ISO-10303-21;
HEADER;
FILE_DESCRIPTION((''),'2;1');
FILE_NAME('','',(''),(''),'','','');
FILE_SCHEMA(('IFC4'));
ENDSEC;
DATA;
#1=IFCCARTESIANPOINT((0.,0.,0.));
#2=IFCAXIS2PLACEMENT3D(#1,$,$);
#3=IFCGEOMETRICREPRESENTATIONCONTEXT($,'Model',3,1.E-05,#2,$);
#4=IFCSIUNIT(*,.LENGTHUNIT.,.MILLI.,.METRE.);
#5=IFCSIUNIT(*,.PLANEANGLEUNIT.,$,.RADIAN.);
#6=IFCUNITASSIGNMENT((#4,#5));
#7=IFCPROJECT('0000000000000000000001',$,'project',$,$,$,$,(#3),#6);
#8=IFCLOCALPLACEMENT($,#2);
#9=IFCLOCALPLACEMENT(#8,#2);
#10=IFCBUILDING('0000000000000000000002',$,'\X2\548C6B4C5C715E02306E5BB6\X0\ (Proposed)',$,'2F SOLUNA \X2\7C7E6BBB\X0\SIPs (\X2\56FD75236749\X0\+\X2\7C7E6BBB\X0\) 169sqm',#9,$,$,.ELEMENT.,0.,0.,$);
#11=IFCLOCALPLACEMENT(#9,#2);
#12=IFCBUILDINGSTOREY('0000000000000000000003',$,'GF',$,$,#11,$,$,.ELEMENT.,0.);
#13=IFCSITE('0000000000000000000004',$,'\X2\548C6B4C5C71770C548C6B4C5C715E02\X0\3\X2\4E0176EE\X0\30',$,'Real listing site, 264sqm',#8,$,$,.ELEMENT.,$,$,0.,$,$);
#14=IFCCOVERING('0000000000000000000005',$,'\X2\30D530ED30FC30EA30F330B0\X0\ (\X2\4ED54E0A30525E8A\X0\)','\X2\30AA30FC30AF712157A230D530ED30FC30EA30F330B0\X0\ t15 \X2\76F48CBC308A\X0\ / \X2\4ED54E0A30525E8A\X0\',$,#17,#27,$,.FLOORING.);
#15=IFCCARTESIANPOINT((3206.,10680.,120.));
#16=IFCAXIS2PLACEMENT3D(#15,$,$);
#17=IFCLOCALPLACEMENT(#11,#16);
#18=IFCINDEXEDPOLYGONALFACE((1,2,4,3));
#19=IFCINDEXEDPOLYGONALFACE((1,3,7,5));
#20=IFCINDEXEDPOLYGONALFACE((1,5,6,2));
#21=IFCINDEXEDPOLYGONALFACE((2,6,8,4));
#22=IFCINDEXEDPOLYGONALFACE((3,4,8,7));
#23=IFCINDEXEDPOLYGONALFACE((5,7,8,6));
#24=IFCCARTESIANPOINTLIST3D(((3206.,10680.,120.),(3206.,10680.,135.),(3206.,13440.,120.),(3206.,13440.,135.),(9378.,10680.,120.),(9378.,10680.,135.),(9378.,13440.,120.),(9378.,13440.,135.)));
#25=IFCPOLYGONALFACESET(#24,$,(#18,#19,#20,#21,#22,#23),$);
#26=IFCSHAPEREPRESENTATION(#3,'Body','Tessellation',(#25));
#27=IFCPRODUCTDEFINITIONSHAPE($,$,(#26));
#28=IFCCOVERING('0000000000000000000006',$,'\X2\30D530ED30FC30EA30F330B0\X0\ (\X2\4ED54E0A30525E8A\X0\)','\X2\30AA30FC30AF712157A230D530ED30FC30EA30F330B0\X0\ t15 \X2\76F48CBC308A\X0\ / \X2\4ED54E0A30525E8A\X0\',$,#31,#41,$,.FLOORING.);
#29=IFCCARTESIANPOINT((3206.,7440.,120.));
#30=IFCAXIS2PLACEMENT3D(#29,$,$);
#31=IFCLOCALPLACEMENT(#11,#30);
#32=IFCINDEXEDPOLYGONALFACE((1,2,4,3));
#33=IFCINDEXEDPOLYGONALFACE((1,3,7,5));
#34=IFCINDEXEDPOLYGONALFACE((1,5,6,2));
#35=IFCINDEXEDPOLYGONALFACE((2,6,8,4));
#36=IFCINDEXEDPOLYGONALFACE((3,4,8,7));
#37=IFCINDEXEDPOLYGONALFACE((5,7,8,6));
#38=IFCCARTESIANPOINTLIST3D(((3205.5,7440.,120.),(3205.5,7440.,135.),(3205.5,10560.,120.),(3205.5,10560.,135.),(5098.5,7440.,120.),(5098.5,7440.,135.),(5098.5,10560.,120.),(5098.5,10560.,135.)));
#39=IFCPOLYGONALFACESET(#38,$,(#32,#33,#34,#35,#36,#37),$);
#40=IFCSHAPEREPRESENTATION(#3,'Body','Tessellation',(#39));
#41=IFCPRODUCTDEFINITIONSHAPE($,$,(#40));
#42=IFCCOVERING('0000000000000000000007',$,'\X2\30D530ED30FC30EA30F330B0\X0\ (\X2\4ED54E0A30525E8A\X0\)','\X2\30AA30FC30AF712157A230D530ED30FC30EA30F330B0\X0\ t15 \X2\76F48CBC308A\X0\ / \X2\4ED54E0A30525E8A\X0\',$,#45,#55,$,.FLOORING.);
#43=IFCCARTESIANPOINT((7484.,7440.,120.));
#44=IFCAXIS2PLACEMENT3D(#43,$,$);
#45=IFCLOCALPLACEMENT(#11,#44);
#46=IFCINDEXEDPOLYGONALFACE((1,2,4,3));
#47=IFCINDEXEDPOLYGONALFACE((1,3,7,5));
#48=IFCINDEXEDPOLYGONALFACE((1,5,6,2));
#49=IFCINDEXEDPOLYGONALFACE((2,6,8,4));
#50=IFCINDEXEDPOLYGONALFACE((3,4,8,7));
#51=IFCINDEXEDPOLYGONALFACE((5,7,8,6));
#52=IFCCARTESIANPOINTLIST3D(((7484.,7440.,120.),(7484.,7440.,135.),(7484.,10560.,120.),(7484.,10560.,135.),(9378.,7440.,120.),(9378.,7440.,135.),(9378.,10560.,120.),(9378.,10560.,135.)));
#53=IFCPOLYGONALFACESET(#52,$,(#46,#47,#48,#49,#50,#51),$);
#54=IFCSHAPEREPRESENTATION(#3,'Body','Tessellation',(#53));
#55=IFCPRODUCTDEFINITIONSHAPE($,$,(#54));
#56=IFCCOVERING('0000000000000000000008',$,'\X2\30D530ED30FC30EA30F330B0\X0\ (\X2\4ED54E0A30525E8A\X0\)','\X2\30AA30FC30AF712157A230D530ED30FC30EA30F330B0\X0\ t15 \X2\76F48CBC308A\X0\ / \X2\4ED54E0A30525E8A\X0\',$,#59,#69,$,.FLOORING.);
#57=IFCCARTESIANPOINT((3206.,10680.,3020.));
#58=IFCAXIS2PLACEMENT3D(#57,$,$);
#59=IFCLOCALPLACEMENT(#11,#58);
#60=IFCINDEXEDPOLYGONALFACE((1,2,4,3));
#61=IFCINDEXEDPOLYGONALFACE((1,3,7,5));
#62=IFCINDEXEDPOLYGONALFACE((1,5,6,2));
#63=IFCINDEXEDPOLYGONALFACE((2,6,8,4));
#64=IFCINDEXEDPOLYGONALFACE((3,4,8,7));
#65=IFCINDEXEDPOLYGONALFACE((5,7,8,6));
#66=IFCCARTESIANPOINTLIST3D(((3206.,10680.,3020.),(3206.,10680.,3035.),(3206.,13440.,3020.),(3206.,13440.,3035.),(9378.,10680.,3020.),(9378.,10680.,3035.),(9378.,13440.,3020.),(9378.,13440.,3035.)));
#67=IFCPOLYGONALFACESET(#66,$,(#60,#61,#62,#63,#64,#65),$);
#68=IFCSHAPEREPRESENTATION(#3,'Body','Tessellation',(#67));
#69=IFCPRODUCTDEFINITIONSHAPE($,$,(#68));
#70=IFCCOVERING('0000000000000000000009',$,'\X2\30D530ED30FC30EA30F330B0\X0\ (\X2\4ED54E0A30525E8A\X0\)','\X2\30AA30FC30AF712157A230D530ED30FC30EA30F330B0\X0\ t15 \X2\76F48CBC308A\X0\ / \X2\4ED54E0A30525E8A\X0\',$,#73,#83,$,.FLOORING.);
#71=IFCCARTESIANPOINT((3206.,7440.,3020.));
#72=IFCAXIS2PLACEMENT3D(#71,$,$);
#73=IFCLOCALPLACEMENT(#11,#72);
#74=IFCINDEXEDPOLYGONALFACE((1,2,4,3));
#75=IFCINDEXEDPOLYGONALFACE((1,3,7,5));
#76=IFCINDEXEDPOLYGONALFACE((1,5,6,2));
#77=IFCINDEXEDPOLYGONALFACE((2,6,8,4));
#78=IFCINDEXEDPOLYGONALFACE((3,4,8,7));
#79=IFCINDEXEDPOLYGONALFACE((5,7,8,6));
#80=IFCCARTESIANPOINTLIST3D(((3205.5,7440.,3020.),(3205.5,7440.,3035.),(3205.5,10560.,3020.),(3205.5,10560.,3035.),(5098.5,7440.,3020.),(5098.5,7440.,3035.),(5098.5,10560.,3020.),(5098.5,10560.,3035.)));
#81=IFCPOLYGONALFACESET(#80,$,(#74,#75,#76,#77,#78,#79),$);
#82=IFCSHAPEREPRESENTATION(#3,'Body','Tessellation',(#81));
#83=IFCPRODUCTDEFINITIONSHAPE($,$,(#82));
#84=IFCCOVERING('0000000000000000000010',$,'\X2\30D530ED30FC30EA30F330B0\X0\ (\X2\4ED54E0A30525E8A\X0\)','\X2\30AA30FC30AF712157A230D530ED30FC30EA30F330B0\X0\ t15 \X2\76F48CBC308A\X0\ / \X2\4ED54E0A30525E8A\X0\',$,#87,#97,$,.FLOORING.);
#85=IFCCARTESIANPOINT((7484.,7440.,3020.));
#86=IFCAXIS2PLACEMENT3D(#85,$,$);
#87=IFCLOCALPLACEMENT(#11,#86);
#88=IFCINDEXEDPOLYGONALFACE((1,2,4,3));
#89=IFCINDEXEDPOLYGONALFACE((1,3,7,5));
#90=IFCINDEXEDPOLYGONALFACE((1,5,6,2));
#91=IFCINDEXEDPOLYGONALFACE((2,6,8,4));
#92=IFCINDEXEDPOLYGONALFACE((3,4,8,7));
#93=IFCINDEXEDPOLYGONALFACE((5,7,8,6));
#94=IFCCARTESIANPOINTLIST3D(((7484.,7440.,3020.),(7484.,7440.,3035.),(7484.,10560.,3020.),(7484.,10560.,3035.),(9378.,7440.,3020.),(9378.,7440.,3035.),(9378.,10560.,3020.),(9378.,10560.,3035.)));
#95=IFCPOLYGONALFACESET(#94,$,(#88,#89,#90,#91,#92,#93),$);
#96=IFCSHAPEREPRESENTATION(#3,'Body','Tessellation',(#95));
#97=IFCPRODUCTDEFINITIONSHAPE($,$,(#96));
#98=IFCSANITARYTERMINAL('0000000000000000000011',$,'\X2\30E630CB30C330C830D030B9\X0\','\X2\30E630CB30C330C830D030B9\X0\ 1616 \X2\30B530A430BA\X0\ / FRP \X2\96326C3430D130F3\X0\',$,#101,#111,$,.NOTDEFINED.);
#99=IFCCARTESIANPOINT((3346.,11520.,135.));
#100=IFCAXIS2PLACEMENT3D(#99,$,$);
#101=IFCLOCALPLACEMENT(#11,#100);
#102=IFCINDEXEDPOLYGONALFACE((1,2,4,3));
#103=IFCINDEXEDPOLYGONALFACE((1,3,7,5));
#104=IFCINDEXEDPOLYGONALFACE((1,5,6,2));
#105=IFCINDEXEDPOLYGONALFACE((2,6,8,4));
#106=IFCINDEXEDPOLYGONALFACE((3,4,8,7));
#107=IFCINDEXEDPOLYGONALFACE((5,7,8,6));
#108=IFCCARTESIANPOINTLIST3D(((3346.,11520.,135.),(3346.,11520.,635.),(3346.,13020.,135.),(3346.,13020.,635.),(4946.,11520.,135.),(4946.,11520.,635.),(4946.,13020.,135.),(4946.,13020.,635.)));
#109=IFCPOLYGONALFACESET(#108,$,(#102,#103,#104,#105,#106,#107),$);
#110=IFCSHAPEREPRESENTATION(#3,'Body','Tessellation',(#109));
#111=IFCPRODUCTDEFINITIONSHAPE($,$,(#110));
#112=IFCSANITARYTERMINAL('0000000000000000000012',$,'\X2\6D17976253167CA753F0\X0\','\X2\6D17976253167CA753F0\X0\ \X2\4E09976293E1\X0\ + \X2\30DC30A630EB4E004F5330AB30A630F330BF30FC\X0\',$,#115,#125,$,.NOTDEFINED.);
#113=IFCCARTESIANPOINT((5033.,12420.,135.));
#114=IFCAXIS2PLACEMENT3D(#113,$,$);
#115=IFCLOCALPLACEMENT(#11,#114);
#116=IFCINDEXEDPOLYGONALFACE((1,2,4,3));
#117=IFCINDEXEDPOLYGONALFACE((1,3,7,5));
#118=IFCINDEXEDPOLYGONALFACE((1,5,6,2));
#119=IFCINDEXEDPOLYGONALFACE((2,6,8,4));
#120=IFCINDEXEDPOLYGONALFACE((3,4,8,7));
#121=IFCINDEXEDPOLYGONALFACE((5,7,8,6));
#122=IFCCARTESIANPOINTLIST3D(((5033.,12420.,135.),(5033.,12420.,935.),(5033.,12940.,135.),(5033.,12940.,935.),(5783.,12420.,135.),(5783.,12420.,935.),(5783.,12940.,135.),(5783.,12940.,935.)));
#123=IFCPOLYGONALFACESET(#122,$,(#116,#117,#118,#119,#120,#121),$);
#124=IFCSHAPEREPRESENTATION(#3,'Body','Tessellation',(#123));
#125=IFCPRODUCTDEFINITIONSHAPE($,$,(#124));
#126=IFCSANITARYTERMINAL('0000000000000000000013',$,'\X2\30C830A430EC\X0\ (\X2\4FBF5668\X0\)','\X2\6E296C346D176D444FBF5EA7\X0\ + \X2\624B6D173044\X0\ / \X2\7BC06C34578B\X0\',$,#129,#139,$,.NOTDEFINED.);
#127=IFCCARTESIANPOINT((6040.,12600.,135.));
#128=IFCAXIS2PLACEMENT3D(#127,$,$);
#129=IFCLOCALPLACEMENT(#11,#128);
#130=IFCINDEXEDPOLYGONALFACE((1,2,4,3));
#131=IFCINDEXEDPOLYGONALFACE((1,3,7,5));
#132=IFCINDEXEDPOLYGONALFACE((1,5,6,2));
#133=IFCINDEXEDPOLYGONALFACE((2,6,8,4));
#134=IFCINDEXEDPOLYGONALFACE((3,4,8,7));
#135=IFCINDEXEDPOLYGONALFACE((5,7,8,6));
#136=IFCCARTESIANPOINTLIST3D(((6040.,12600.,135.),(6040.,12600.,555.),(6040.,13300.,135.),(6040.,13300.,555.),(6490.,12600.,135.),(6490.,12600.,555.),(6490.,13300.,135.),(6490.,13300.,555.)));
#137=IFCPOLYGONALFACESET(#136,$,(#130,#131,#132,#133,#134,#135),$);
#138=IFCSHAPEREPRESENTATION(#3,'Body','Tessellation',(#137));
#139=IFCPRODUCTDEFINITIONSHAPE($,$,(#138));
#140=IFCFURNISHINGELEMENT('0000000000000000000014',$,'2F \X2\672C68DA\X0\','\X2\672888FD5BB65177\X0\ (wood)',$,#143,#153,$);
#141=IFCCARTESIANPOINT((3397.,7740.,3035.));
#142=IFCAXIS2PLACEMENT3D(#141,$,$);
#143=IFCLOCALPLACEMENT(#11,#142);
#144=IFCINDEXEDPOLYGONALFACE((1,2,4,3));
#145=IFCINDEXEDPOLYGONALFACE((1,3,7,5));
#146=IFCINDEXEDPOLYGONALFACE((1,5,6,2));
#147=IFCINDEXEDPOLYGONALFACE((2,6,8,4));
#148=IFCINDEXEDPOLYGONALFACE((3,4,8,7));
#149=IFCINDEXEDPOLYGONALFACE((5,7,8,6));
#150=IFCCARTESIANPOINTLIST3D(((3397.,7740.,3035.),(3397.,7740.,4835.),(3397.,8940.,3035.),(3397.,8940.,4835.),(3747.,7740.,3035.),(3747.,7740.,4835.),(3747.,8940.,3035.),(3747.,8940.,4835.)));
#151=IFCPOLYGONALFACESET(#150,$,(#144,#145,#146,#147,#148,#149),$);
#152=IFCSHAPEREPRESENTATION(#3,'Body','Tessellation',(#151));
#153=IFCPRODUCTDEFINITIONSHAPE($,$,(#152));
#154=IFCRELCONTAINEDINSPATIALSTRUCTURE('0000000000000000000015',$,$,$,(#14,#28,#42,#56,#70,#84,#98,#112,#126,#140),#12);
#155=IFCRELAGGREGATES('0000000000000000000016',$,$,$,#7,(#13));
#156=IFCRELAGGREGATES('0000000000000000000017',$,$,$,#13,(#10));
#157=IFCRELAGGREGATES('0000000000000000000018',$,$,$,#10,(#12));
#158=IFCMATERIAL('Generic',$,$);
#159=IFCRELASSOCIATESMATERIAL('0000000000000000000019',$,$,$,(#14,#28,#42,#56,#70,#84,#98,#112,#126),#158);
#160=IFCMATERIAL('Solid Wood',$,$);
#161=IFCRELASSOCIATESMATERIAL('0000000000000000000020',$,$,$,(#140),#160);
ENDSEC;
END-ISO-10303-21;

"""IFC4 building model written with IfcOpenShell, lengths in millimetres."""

from ifc_helpers import new_model, si_unit, frame, frame_2d, origin, place, context, project, spatial, rectangle, extrude, material, element, save


model = new_model("IFC4")

# Units and contexts
model_context = context("Model", 3, precision=1e-05, world=origin())
ifc_project = project(units=[si_unit("LENGTHUNIT", "METRE", prefix="MILLI"), si_unit("PLANEANGLEUNIT", "RADIAN")], contexts=[model_context])

# Site, building, storey
site_placement = place(None, origin())
site = spatial("IfcSite", under=ifc_project, at=site_placement, Name="和歌山県和歌山市3丁目30", ObjectType="Real listing site, 264sqm", CompositionType="ELEMENT", RefElevation=0.0)
building_placement = place(site_placement, origin())
building = spatial("IfcBuilding", under=site, at=building_placement, Name="和歌山市の家 (Proposed)", ObjectType="2F SOLUNA 籾殻SIPs (国産杉+籾殻) 169sqm", CompositionType="ELEMENT", ElevationOfRefHeight=0.0, ElevationOfTerrain=0.0)
storey_placement = place(building_placement, origin())
storey = spatial("IfcBuildingStorey", under=building, at=storey_placement, Name="GF", CompositionType="ELEMENT", Elevation=0.0)

# Shared definitions
ifc_material_1 = material(Name="Solid Wood")
ifc_material_2 = material(Name="Generic")

# Coverings
covering_1_placement = place(storey_placement, frame((3206.0, 10680.0, 120.0)))
element("IfcCovering", 1, at=covering_1_placement, inside=storey, material=ifc_material_2, Name="フローリング (仕上げ床)", Description="オーク無垢フローリング t15 直貼り / 仕上げ床", PredefinedType="FLOORING", context=model_context, shape_type="SweptSolid", body=[
    extrude(rectangle(XDim=6172.0, YDim=2760.0, at=frame_2d((3086.0, 1380.0))), frame((3206.0, 10680.0, 120.0)), (0.0, 0.0, 1.0), 15.0),
])
covering_2_placement = place(storey_placement, frame((3206.0, 7440.0, 120.0)))
element("IfcCovering", 2, at=covering_2_placement, inside=storey, material=ifc_material_2, Name="フローリング (仕上げ床)", Description="オーク無垢フローリング t15 直貼り / 仕上げ床", PredefinedType="FLOORING", context=model_context, shape_type="SweptSolid", body=[
    extrude(rectangle(XDim=1893.0, YDim=3120.0, at=frame_2d((946.0, 1560.0))), frame((3206.0, 7440.0, 120.0)), (0.0, 0.0, 1.0), 15.0),
])
covering_3_placement = place(storey_placement, frame((7484.0, 7440.0, 120.0)))
element("IfcCovering", 3, at=covering_3_placement, inside=storey, material=ifc_material_2, Name="フローリング (仕上げ床)", Description="オーク無垢フローリング t15 直貼り / 仕上げ床", PredefinedType="FLOORING", context=model_context, shape_type="SweptSolid", body=[
    extrude(rectangle(XDim=1894.0, YDim=3120.0, at=frame_2d((947.0, 1560.0))), frame((7484.0, 7440.0, 120.0)), (0.0, 0.0, 1.0), 15.0),
])
covering_4_placement = place(storey_placement, frame((3206.0, 10680.0, 3020.0)))
element("IfcCovering", 4, at=covering_4_placement, inside=storey, material=ifc_material_2, Name="フローリング (仕上げ床)", Description="オーク無垢フローリング t15 直貼り / 仕上げ床", PredefinedType="FLOORING", context=model_context, shape_type="SweptSolid", body=[
    extrude(rectangle(XDim=6172.0, YDim=2760.0, at=frame_2d((3086.0, 1380.0))), frame((3206.0, 10680.0, 3020.0)), (0.0, 0.0, 1.0), 15.0),
])
covering_5_placement = place(storey_placement, frame((3206.0, 7440.0, 3020.0)))
element("IfcCovering", 5, at=covering_5_placement, inside=storey, material=ifc_material_2, Name="フローリング (仕上げ床)", Description="オーク無垢フローリング t15 直貼り / 仕上げ床", PredefinedType="FLOORING", context=model_context, shape_type="SweptSolid", body=[
    extrude(rectangle(XDim=1893.0, YDim=3120.0, at=frame_2d((946.0, 1560.0))), frame((3206.0, 7440.0, 3020.0)), (0.0, 0.0, 1.0), 15.0),
])
covering_6_placement = place(storey_placement, frame((7484.0, 7440.0, 3020.0)))
element("IfcCovering", 6, at=covering_6_placement, inside=storey, material=ifc_material_2, Name="フローリング (仕上げ床)", Description="オーク無垢フローリング t15 直貼り / 仕上げ床", PredefinedType="FLOORING", context=model_context, shape_type="SweptSolid", body=[
    extrude(rectangle(XDim=1894.0, YDim=3120.0, at=frame_2d((947.0, 1560.0))), frame((7484.0, 7440.0, 3020.0)), (0.0, 0.0, 1.0), 15.0),
])

# Sanitary terminals
sanitary_terminal_1_placement = place(storey_placement, frame((3346.0, 11520.0, 135.0)))
element("IfcSanitaryTerminal", 7, at=sanitary_terminal_1_placement, inside=storey, material=ifc_material_2, Name="ユニットバス", Description="ユニットバス 1616 サイズ / FRP 防水パン", PredefinedType="NOTDEFINED", context=model_context, shape_type="SweptSolid", body=[
    extrude(rectangle(XDim=1600.0, YDim=1500.0, at=frame_2d((800.0, 750.0))), frame((3346.0, 11520.0, 135.0)), (0.0, 0.0, 1.0), 500.0),
])
sanitary_terminal_2_placement = place(storey_placement, frame((5033.0, 12420.0, 135.0)))
element("IfcSanitaryTerminal", 8, at=sanitary_terminal_2_placement, inside=storey, material=ifc_material_2, Name="洗面化粧台", Description="洗面化粧台 三面鏡 + ボウル一体カウンター", PredefinedType="NOTDEFINED", context=model_context, shape_type="SweptSolid", body=[
    extrude(rectangle(XDim=750.0, YDim=520.0, at=frame_2d((375.0, 260.0))), frame((5033.0, 12420.0, 135.0)), (0.0, 0.0, 1.0), 800.0),
])
sanitary_terminal_3_placement = place(storey_placement, frame((6040.0, 12600.0, 135.0)))
element("IfcSanitaryTerminal", 9, at=sanitary_terminal_3_placement, inside=storey, material=ifc_material_2, Name="トイレ (便器)", Description="温水洗浄便座 + 手洗い / 節水型", PredefinedType="NOTDEFINED", context=model_context, shape_type="SweptSolid", body=[
    extrude(rectangle(XDim=450.0, YDim=700.0, at=frame_2d((225.0, 350.0))), frame((6040.0, 12600.0, 135.0)), (0.0, 0.0, 1.0), 420.0),
])

# Furnishing element
furnishing_placement = place(storey_placement, frame((3397.0, 7740.0, 3035.0)))
element("IfcFurnishingElement", 10, at=furnishing_placement, inside=storey, material=ifc_material_1, Name="2F 本棚", Description="木製家具 (wood)", context=model_context, shape_type="SweptSolid", body=[
    extrude(rectangle(XDim=350.0, YDim=1200.0, at=frame_2d((175.0, 600.0))), frame((3397.0, 7740.0, 3035.0)), (0.0, 0.0, 1.0), 1800.0),
])

save(model, "model.ifc")
